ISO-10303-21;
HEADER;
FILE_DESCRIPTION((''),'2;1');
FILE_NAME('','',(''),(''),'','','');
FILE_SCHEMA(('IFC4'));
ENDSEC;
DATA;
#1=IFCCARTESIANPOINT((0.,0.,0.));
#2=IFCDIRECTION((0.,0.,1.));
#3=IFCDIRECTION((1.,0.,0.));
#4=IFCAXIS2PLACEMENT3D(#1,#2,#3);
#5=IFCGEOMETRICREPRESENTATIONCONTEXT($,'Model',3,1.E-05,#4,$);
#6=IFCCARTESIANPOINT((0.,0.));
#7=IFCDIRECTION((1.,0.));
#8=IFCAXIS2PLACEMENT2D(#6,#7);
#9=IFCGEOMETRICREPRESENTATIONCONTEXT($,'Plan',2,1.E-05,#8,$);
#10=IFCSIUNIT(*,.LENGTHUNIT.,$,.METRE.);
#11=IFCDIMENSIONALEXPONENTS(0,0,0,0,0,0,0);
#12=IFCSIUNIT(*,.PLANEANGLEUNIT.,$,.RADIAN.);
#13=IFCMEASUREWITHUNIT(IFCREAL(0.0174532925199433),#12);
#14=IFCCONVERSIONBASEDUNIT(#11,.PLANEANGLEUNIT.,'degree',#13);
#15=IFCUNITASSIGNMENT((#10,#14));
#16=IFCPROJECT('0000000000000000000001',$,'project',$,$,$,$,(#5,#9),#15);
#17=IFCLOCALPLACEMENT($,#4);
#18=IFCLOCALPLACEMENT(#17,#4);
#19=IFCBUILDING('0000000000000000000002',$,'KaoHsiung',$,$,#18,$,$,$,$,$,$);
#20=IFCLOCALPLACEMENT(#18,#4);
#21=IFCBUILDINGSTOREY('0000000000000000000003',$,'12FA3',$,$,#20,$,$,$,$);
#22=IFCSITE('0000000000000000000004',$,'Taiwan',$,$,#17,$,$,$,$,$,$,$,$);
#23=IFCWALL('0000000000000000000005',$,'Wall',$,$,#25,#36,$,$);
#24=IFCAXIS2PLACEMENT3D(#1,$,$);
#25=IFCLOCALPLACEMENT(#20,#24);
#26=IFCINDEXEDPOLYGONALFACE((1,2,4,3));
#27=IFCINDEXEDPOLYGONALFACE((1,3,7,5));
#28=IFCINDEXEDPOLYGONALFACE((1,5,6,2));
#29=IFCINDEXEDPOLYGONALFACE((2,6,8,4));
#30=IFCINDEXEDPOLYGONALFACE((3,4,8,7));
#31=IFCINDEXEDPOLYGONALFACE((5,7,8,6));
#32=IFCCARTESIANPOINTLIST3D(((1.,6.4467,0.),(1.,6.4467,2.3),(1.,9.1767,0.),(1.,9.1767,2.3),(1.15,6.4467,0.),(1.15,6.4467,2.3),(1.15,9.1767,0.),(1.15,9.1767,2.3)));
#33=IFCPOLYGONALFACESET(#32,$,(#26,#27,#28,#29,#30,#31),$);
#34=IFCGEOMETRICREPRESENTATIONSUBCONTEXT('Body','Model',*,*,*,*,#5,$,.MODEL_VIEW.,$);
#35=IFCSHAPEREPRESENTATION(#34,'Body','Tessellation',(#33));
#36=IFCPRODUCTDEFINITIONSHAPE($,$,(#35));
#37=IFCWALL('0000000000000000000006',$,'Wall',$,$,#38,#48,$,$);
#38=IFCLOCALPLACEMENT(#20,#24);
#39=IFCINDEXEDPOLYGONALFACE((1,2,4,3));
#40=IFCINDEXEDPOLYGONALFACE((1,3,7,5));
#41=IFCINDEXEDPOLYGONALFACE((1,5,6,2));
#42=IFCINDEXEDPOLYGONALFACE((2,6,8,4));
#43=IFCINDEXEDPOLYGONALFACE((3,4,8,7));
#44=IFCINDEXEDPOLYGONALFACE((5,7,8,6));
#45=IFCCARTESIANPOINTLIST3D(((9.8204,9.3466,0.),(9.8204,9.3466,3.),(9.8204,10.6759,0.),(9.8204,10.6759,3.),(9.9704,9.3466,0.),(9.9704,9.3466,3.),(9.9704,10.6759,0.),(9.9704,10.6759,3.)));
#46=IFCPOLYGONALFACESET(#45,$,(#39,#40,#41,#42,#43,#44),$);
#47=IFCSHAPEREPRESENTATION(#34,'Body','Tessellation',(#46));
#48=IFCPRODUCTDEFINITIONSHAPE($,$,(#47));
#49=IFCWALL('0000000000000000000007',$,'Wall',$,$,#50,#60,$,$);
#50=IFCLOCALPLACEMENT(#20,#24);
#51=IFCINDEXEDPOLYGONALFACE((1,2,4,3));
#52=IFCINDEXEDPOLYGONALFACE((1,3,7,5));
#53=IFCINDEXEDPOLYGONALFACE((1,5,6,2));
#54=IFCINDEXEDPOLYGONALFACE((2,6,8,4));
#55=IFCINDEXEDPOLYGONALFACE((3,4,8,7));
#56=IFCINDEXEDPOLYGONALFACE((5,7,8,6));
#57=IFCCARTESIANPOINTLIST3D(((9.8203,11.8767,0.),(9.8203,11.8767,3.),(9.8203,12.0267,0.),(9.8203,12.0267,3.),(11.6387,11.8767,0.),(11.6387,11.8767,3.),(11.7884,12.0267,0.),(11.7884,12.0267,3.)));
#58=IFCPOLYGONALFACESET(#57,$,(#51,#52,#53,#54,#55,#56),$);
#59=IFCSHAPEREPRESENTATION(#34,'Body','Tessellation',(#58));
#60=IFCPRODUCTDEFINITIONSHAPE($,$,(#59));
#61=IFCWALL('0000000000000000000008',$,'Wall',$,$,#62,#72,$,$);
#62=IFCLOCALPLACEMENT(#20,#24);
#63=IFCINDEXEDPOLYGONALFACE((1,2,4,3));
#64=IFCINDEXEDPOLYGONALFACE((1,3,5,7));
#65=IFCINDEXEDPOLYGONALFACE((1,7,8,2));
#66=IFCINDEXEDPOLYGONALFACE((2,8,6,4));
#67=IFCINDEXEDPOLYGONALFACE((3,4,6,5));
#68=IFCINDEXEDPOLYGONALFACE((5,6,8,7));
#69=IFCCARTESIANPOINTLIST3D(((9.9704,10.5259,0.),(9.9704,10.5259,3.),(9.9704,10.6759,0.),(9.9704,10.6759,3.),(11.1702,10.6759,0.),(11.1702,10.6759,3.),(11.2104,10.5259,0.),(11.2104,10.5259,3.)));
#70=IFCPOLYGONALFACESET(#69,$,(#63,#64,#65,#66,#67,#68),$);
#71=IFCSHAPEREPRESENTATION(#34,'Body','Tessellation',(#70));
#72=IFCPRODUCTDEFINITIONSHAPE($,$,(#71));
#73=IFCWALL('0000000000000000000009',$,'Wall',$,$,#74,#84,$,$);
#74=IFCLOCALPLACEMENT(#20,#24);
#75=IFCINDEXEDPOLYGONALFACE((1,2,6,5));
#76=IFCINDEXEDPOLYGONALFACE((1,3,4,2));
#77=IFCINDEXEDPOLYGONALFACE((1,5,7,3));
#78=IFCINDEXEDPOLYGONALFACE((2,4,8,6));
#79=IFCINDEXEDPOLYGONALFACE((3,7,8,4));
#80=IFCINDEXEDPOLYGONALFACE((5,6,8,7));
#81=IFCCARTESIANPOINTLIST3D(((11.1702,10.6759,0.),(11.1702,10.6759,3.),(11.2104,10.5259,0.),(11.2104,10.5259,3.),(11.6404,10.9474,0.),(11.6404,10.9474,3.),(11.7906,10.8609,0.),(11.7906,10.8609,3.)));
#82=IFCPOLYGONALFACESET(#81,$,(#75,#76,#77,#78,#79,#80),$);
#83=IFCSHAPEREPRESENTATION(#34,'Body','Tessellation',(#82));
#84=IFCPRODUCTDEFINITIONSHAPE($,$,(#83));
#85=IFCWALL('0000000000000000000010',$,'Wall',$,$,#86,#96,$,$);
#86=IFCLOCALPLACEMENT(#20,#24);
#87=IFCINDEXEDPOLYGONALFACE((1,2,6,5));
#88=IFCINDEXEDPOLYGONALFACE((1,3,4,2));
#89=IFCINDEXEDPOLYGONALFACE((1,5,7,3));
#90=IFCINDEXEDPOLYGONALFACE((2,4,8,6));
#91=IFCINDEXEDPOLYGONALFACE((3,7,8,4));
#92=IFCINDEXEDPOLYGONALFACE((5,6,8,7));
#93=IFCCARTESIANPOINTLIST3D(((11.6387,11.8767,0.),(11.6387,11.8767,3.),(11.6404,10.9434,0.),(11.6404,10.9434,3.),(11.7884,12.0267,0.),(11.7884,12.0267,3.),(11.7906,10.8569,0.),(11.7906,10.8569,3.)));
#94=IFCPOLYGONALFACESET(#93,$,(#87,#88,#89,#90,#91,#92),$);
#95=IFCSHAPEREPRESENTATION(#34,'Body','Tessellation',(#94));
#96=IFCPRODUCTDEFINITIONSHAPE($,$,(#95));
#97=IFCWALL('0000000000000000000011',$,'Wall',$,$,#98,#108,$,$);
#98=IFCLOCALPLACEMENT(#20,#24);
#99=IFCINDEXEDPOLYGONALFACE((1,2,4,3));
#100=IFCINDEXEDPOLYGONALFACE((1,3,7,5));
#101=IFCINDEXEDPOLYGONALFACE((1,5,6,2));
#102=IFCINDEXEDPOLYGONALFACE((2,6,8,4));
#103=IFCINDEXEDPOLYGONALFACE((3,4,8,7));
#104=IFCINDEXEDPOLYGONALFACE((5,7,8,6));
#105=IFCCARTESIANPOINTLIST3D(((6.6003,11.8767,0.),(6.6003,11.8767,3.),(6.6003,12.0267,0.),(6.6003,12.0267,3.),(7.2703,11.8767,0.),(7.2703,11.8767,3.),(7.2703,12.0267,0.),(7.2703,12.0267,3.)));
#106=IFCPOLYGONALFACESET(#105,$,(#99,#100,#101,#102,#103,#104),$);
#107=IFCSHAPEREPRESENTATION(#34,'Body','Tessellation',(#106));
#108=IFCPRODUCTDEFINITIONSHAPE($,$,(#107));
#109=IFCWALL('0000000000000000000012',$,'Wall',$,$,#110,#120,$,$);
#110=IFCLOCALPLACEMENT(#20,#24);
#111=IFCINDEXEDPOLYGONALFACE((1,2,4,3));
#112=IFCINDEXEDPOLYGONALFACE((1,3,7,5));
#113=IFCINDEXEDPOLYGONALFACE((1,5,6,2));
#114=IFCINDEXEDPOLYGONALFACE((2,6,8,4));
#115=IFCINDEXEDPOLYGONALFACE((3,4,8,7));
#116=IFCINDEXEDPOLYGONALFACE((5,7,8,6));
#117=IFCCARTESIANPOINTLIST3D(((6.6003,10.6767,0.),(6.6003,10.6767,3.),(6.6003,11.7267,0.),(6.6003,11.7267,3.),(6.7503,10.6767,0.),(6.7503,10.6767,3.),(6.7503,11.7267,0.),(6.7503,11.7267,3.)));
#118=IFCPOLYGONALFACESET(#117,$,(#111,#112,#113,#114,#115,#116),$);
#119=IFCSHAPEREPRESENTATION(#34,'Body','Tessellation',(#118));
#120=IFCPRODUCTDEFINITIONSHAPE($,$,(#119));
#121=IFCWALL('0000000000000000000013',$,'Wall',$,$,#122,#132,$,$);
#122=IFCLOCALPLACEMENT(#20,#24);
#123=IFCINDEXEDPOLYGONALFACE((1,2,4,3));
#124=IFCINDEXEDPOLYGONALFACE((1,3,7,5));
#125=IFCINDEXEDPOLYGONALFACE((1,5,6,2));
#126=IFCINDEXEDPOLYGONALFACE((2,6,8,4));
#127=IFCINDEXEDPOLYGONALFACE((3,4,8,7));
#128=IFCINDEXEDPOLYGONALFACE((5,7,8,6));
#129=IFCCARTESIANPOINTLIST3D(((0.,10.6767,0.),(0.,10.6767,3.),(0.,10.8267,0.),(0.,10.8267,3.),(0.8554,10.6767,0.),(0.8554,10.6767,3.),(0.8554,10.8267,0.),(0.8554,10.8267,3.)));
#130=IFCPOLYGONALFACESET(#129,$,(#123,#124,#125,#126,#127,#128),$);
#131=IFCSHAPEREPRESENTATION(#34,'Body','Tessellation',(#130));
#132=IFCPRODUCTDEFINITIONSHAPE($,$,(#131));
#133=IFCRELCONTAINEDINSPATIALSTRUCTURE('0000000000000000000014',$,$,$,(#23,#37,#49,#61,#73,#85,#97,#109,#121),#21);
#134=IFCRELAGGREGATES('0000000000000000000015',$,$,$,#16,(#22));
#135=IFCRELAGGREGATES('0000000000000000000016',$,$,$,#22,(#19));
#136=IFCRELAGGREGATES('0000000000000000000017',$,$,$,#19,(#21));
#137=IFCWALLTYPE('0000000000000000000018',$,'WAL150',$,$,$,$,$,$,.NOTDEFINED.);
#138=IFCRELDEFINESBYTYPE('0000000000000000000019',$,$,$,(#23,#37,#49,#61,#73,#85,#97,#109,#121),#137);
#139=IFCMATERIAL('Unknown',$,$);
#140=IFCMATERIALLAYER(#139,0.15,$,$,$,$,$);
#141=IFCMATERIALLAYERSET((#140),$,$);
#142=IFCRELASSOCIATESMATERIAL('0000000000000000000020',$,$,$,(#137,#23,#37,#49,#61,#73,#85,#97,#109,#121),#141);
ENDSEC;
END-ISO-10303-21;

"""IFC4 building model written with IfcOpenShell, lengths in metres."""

from ifc_helpers import new_model, entity, si_unit, converted_unit, frame, origin_with_axes, origin_2d_with_axis, place, context, subcontext, project, spatial, line, indexed_curve, outline, extrude, material, layer, layer_set, layer_usage, type_object, element, save


model = new_model("IFC4")

# Units and contexts
model_context = context("Model", 3, precision=1e-05, world=origin_with_axes())
plan_context = context("Plan", 2, precision=1e-05, world=origin_2d_with_axis())
body_context_1 = subcontext(model_context, "Body", "Model", "MODEL_VIEW")
ifc_project = project(units=[si_unit("LENGTHUNIT", "METRE"), converted_unit("PLANEANGLEUNIT", "degree", entity("IfcReal", 0.0174532925199433), si_unit("PLANEANGLEUNIT", "RADIAN"), dimensions=[0, 0, 0, 0, 0, 0, 0])], contexts=[model_context, plan_context])

# Site, building, storey
site_placement = place(None, origin_with_axes())
site = spatial("IfcSite", under=ifc_project, at=site_placement, Name="Taiwan")
building_placement = place(site_placement, origin_with_axes())
building = spatial("IfcBuilding", under=site, at=building_placement, Name="KaoHsiung")
storey_placement = place(building_placement, origin_with_axes())
storey = spatial("IfcBuildingStorey", under=building, at=storey_placement, Name="12FA3")

# Shared definitions
ifc_material = material(Name="Unknown")

# Walls
ifc_layer_1 = layer(ifc_material, 0.15)
ifc_layer_set_1 = layer_set([ifc_layer_1])
wall_type_1 = type_object("IfcWallType", Name="WAL150", PredefinedType="NOTDEFINED", material=ifc_layer_set_1)
ifc_layer_usage_1 = layer_usage(ifc_layer_set_1, "AXIS2", "POSITIVE", 0.0)
wall_1_placement = place(storey_placement, frame((1.0, 9.1767, 0.0), z_axis=(0.0, 0.0, 1.0), x_axis=(0.0, -1.0, 0.0)))
element("IfcWall", 1, at=wall_1_placement, inside=storey, type_object=wall_type_1, material=ifc_layer_usage_1, Name="Wall", context=body_context_1, shape_type="SweptSolid", body=[
    extrude(outline(indexed_curve([(0.0, 0.0), (0.0, 0.15), (2.73, 0.15), (2.73, 0.0)], segments=[line(1, 2, 3, 4, 1)])), origin_with_axes(), (0.0, 0.0, 1.0), 2.3),
])
ifc_layer_usage_2 = layer_usage(ifc_layer_set_1, "AXIS2", "POSITIVE", 0.0)
wall_2_placement = place(storey_placement, frame((9.9704, 9.3466, 0.0), z_axis=(0.0, 0.0, 1.0), x_axis=(0.0, 1.0, 0.0)))
element("IfcWall", 2, at=wall_2_placement, inside=storey, type_object=wall_type_1, material=ifc_layer_usage_2, Name="Wall", context=body_context_1, shape_type="SweptSolid", body=[
    extrude(outline(indexed_curve([(0.0, 0.0), (0.0, 0.15), (1.3293, 0.15), (1.3293, 0.0)], segments=[line(1, 2, 3, 4, 1)])), origin_with_axes(), (0.0, 0.0, 1.0), 3.0),
])
ifc_layer_usage_3 = layer_usage(ifc_layer_set_1, "AXIS2", "POSITIVE", 0.0)
wall_3_placement = place(storey_placement, frame((11.7884, 12.0267, 0.0), z_axis=(0.0, 0.0, 1.0), x_axis=(-1.0, 0.0, 0.0)))
element("IfcWall", 3, at=wall_3_placement, inside=storey, type_object=wall_type_1, material=ifc_layer_usage_3, Name="Wall", context=body_context_1, shape_type="SweptSolid", body=[
    extrude(outline(indexed_curve([(0.0, 0.0), (0.1497, 0.15), (1.9681, 0.15), (1.9681, 0.0)], segments=[line(1, 2, 3, 4, 1)])), origin_with_axes(), (0.0, 0.0, 1.0), 3.0),
])
ifc_layer_usage_4 = layer_usage(ifc_layer_set_1, "AXIS2", "POSITIVE", 0.0)
wall_4_placement = place(storey_placement, frame((9.9704, 10.5259, 0.0), z_axis=(0.0, 0.0, 1.0), x_axis=(1.0, 0.0, 0.0)))
element("IfcWall", 4, at=wall_4_placement, inside=storey, type_object=wall_type_1, material=ifc_layer_usage_4, Name="Wall", context=body_context_1, shape_type="SweptSolid", body=[
    extrude(outline(indexed_curve([(0.0, 0.0), (0.0, 0.15), (1.1998, 0.15), (1.24, 0.0)], segments=[line(1, 2, 3, 4, 1)])), origin_with_axes(), (0.0, 0.0, 1.0), 3.0),
])
ifc_layer_usage_5 = layer_usage(ifc_layer_set_1, "AXIS2", "POSITIVE", 0.0)
wall_5_placement = place(storey_placement, frame((11.2104, 10.5259, 0.0), z_axis=(0.0, 0.0, 1.0), x_axis=(0.866026, 0.5, 0.0)))
element("IfcWall", 5, at=wall_5_placement, inside=storey, type_object=wall_type_1, material=ifc_layer_usage_5, Name="Wall", context=body_context_1, shape_type="SweptSolid", body=[
    extrude(outline(indexed_curve([(0.0, 0.0), (0.0402, 0.15), (0.5832, 0.15), (0.67, 0.0)], segments=[line(1, 2, 3, 4, 1)])), origin_with_axes(), (0.0, 0.0, 1.0), 3.0),
])
ifc_layer_usage_6 = layer_usage(ifc_layer_set_1, "AXIS2", "POSITIVE", 0.0)
wall_6_placement = place(storey_placement, frame((11.7906, 10.8569, 0.0), z_axis=(0.0, 0.0, 1.0), x_axis=(-0.001882, 0.999998, 0.0)))
element("IfcWall", 6, at=wall_6_placement, inside=storey, type_object=wall_type_1, material=ifc_layer_usage_6, Name="Wall", context=body_context_1, shape_type="SweptSolid", body=[
    extrude(outline(indexed_curve([(0.0, 0.0), (0.0868, 0.15), (1.02, 0.15), (1.1698, 0.0)], segments=[line(1, 2, 3, 4, 1)])), origin_with_axes(), (0.0, 0.0, 1.0), 3.0),
])
ifc_layer_usage_7 = layer_usage(ifc_layer_set_1, "AXIS2", "POSITIVE", 0.0)
wall_7_placement = place(storey_placement, frame((7.2703, 12.0267, 0.0), z_axis=(0.0, 0.0, 1.0), x_axis=(-1.0, 0.0, 0.0)))
element("IfcWall", 7, at=wall_7_placement, inside=storey, type_object=wall_type_1, material=ifc_layer_usage_7, Name="Wall", context=body_context_1, shape_type="SweptSolid", body=[
    extrude(outline(indexed_curve([(0.0, 0.0), (0.0, 0.15), (0.67, 0.15), (0.67, 0.0)], segments=[line(1, 2, 3, 4, 1)])), origin_with_axes(), (0.0, 0.0, 1.0), 3.0),
])

# Wall
ifc_layer_usage_8 = layer_usage(ifc_layer_set_1, "AXIS2", "POSITIVE", 0.0)
wall_8_placement = place(storey_placement, frame((6.6003, 11.7267, 0.0), z_axis=(0.0, 0.0, 1.0), x_axis=(0.0, -1.0, 0.0)))
element("IfcWall", 8, at=wall_8_placement, inside=storey, type_object=wall_type_1, material=ifc_layer_usage_8, Name="Wall", context=body_context_1, shape_type="SweptSolid", body=[
    extrude(outline(indexed_curve([(0.0, 0.0), (0.0, 0.15), (1.05, 0.15), (1.05, 0.0)], segments=[line(1, 2, 3, 4, 1)])), origin_with_axes(), (0.0, 0.0, 1.0), 3.0),
])

# Wall
ifc_layer_usage_9 = layer_usage(ifc_layer_set_1, "AXIS2", "POSITIVE", 0.0)
wall_9_placement = place(storey_placement, frame((0.8554, 10.8267, 0.0), z_axis=(0.0, 0.0, 1.0), x_axis=(-1.0, 0.0, 0.0)))
element("IfcWall", 9, at=wall_9_placement, inside=storey, type_object=wall_type_1, material=ifc_layer_usage_9, Name="Wall", context=body_context_1, shape_type="SweptSolid", body=[
    extrude(outline(indexed_curve([(0.0, 0.0), (0.0, 0.15), (0.8553, 0.15), (0.8553, 0.0)], segments=[line(1, 2, 3, 4, 1)])), origin_with_axes(), (0.0, 0.0, 1.0), 3.0),
])

save(model, "model.ifc")
